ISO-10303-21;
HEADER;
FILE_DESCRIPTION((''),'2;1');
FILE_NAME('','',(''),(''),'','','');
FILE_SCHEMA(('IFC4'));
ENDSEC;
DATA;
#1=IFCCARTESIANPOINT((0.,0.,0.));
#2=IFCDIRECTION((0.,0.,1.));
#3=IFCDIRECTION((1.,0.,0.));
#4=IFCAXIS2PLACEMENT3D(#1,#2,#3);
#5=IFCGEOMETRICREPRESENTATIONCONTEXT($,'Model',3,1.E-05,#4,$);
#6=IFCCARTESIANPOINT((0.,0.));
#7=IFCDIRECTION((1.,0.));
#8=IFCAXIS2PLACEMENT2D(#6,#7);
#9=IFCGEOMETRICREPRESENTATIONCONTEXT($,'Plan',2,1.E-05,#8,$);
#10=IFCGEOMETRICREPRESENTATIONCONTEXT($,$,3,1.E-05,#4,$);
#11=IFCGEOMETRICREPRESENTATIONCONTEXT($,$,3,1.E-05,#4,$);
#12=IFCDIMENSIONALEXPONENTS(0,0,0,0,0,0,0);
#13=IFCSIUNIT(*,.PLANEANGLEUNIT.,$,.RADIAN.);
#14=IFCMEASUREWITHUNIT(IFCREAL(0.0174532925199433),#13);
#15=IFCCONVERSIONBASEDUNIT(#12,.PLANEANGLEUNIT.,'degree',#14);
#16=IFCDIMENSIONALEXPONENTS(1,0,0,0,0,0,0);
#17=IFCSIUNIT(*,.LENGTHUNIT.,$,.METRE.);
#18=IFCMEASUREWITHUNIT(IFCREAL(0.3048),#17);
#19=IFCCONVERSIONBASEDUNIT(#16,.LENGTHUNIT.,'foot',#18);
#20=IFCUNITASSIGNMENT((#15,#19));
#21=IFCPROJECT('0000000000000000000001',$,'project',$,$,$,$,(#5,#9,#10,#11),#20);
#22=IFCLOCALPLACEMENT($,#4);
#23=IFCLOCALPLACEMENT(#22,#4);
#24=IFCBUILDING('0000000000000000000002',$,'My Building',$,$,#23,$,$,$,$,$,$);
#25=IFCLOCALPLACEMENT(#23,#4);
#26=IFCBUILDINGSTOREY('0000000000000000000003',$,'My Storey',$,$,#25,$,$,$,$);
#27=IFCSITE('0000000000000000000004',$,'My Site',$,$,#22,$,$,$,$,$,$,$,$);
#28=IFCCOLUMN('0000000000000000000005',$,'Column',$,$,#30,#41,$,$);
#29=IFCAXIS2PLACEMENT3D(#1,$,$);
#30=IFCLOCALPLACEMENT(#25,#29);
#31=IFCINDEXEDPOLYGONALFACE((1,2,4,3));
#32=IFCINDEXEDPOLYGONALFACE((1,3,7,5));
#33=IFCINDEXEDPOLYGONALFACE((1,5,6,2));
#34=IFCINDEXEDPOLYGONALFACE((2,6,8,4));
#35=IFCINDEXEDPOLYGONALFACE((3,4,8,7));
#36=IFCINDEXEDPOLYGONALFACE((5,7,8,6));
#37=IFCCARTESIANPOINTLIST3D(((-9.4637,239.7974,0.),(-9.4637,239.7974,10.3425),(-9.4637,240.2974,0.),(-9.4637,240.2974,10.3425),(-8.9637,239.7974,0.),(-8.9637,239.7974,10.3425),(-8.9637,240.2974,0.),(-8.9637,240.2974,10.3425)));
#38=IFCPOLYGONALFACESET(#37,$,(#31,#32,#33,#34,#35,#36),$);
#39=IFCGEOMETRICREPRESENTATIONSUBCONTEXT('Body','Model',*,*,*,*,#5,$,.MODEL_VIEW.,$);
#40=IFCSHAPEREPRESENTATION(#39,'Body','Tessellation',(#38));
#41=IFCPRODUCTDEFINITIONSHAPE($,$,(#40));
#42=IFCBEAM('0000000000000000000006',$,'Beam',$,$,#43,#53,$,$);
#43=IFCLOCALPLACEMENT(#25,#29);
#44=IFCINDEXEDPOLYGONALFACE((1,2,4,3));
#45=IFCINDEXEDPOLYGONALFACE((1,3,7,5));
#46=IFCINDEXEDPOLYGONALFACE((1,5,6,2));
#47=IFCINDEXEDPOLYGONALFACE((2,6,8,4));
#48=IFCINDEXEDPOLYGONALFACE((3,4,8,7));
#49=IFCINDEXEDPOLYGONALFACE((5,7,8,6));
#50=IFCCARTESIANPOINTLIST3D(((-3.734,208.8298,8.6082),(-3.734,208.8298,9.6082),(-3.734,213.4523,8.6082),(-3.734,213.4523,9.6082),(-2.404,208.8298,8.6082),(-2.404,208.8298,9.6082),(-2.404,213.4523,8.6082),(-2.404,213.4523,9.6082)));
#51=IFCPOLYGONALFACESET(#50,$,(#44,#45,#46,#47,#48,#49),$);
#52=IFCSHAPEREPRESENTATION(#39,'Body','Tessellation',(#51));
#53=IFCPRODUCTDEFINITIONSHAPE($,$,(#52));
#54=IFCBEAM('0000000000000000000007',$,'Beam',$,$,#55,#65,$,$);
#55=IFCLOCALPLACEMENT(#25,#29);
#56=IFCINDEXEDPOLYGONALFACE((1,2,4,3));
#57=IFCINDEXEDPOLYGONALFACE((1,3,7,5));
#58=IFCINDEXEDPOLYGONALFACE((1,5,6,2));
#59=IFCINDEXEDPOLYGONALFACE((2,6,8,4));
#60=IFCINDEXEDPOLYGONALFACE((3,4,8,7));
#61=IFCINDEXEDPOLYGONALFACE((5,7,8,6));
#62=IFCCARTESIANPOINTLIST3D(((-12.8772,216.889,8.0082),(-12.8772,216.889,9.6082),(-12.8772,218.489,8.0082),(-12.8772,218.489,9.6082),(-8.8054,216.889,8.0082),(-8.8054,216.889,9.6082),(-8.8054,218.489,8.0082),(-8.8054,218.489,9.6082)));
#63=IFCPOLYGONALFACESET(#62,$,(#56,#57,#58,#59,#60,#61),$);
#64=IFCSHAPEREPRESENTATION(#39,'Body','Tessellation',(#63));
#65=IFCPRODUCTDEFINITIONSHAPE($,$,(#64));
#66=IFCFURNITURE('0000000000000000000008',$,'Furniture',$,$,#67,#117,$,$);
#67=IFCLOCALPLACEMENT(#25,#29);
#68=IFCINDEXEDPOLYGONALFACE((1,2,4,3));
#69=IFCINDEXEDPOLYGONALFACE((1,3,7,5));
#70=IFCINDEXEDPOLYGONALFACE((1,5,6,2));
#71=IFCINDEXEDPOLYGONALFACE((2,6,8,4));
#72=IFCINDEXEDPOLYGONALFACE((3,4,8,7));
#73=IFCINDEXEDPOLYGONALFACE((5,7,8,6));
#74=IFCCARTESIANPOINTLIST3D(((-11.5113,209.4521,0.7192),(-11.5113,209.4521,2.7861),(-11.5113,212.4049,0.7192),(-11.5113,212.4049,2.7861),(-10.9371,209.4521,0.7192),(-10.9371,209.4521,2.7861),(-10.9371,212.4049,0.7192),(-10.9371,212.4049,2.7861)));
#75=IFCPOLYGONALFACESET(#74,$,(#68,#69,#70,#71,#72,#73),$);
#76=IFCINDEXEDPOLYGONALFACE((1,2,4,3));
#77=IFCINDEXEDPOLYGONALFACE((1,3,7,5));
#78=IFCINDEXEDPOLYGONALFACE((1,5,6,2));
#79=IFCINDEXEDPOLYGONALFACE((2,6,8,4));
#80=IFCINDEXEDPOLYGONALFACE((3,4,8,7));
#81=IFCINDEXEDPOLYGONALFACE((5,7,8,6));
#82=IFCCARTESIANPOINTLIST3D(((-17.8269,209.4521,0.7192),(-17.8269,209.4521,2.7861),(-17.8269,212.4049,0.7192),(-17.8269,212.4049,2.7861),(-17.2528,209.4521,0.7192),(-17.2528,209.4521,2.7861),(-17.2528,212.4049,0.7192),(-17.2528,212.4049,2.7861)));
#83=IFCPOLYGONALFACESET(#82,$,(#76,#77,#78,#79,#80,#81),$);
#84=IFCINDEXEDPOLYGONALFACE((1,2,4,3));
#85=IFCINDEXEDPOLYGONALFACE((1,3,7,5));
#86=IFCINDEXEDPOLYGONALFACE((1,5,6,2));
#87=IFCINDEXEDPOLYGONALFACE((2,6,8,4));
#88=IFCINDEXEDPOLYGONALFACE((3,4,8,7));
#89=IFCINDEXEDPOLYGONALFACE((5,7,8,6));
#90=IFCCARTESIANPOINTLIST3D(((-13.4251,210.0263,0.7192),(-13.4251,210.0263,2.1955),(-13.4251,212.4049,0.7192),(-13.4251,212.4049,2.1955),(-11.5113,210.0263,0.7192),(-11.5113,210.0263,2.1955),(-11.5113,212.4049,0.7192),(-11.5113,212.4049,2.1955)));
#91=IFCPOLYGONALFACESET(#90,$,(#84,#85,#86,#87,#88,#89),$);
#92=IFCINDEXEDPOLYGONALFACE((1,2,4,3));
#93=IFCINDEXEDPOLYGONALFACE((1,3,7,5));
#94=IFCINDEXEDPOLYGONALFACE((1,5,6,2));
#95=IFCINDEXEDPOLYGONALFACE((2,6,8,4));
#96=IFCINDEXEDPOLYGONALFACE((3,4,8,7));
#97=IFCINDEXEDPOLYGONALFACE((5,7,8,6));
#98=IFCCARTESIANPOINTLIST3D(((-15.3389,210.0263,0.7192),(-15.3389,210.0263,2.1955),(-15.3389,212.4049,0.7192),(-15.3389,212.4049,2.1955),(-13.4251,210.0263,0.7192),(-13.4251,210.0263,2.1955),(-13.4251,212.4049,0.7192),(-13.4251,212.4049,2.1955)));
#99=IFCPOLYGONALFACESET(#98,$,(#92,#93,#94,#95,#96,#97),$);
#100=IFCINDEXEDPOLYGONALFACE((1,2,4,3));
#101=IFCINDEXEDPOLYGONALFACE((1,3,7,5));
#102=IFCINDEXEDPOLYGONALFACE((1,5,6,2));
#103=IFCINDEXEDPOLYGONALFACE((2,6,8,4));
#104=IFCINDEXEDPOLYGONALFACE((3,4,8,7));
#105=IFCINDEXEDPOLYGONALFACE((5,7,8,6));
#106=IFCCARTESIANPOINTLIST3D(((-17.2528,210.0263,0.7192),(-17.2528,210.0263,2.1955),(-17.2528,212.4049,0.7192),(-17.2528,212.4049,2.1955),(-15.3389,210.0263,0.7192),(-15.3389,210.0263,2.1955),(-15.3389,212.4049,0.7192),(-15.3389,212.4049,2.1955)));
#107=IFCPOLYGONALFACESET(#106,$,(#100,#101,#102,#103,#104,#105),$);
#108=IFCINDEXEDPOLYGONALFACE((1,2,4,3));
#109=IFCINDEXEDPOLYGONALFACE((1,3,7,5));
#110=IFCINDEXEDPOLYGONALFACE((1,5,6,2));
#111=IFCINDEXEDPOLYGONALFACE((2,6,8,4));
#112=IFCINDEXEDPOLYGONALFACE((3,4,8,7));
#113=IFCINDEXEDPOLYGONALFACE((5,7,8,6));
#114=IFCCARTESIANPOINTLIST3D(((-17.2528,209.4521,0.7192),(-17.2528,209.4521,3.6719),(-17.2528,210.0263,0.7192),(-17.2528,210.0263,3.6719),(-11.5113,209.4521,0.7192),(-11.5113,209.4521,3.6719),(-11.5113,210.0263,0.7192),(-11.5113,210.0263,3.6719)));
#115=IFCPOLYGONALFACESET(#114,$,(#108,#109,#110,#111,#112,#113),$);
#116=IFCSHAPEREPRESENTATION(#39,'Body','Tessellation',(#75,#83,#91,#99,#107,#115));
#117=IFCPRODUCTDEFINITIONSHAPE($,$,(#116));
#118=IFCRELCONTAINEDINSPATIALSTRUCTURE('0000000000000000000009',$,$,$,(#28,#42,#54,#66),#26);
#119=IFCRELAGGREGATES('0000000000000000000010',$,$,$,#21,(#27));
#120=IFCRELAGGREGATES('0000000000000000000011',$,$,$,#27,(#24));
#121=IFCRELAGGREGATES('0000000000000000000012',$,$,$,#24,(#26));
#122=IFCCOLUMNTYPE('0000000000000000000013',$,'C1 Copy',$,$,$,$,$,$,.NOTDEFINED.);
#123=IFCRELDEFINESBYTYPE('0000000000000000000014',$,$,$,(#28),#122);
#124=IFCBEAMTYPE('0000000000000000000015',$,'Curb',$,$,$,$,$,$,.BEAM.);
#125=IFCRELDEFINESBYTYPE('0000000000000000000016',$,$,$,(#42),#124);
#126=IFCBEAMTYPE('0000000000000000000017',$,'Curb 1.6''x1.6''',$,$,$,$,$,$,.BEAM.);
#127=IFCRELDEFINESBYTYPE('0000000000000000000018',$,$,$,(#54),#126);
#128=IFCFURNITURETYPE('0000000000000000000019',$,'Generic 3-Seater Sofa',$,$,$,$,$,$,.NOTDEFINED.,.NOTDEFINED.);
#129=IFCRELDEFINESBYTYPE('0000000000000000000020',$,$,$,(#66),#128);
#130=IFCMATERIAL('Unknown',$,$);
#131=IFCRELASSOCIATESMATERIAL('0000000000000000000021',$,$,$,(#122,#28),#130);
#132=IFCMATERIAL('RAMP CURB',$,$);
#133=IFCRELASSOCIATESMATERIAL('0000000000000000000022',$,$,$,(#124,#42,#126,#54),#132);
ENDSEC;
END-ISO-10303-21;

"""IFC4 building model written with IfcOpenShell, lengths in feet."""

from ifc_helpers import new_model, entity, si_unit, converted_unit, frame, origin_with_axes, origin_2d_with_axis, place, context, subcontext, project, spatial, line, indexed_curve, rectangle, outline, extrude, shape, source, transform, mapped, material, material_profile, profile_set, profile_usage, type_object, type_shapes, element, save


model = new_model("IFC4")

# Units and contexts
model_context = context("Model", 3, precision=1e-05, world=origin_with_axes())
plan_context = context("Plan", 2, precision=1e-05, world=origin_2d_with_axis())
context_of_model_1 = context(None, 3, precision=1e-05, world=origin_with_axes())
context_of_model_2 = context(None, 3, precision=1e-05, world=origin_with_axes())
body_context_1 = subcontext(model_context, "Body", "Model", "MODEL_VIEW")
body_context_2 = subcontext(plan_context, "Body", "Plan", "PLAN_VIEW")
ifc_project = project(units=[converted_unit("PLANEANGLEUNIT", "degree", entity("IfcReal", 0.0174532925199433), si_unit("PLANEANGLEUNIT", "RADIAN"), dimensions=[0, 0, 0, 0, 0, 0, 0]), converted_unit("LENGTHUNIT", "foot", entity("IfcReal", 0.3048), si_unit("LENGTHUNIT", "METRE"), dimensions=[1, 0, 0, 0, 0, 0, 0])], contexts=[model_context, plan_context, context_of_model_1, context_of_model_2])

# Site, building, storey
site_placement = place(None, origin_with_axes())
site = spatial("IfcSite", under=ifc_project, at=site_placement, Name="My Site")
building_placement = place(site_placement, origin_with_axes())
building = spatial("IfcBuilding", under=site, at=building_placement, Name="My Building")
storey_placement = place(building_placement, origin_with_axes())
storey = spatial("IfcBuildingStorey", under=building, at=storey_placement, Name="My Storey")

# Column
ifc_material_1 = material(Name="Unknown")
ifc_material_profile_1 = material_profile(ifc_material_1, rectangle(XDim=0.5, YDim=0.5))
ifc_profile_set_1 = profile_set([ifc_material_profile_1])
ifc_profile_usage_1 = profile_usage(ifc_profile_set_1, cardinal=5)
column_type = type_object("IfcColumnType", Name="C1 Copy", PredefinedType="NOTDEFINED", material=ifc_profile_set_1)
column_placement = place(storey_placement, frame((-9.2137, 240.0474, 0.0), z_axis=(0.0, 0.0, 1.0), x_axis=(1.0, 0.0, 0.0)))
element("IfcColumn", 1, at=column_placement, inside=storey, type_object=column_type, material=ifc_profile_usage_1, Name="Column", context=body_context_1, shape_type="SweptSolid", body=[
    extrude(rectangle(XDim=0.5, YDim=0.5), origin_with_axes(), (0.0, 0.0, 1.0), 10.3425),
])

# Beams
ifc_material_2 = material(Name="RAMP CURB")
ifc_material_profile_2 = material_profile(ifc_material_2, rectangle(XDim=1.33, YDim=1.0))
ifc_profile_set_2 = profile_set([ifc_material_profile_2])
ifc_profile_usage_2 = profile_usage(ifc_profile_set_2, cardinal=5)
beam_type_1 = type_object("IfcBeamType", Name="Curb", PredefinedType="BEAM", material=ifc_profile_set_2)
beam_1_placement = place(storey_placement, frame((-3.069, 208.8298, 9.1082), z_axis=(0.0, 1.0, 0.0), x_axis=(-1.0, 0.0, 0.0)))
element("IfcBeam", 2, at=beam_1_placement, inside=storey, type_object=beam_type_1, material=ifc_profile_usage_2, Name="Beam", context=body_context_1, shape_type="SweptSolid", body=[
    extrude(rectangle(XDim=1.33, YDim=1.0), origin_with_axes(), (0.0, 0.0, 1.0), 4.6225),
])
ifc_material_profile_3 = material_profile(ifc_material_2, rectangle(XDim=1.6, YDim=1.6))
ifc_profile_set_3 = profile_set([ifc_material_profile_3])
ifc_profile_usage_3 = profile_usage(ifc_profile_set_3, cardinal=5)
beam_type_2 = type_object("IfcBeamType", Name="Curb 1.6'x1.6'", PredefinedType="BEAM", material=ifc_profile_set_3)
beam_2_placement = place(storey_placement, frame((-8.8054, 217.689, 8.8082), z_axis=(-1.0, 0.0, 0.0), x_axis=(0.0, -1.0, 0.0)))
element("IfcBeam", 3, at=beam_2_placement, inside=storey, type_object=beam_type_2, material=ifc_profile_usage_3, Name="Beam", context=body_context_1, shape_type="SweptSolid", body=[
    extrude(rectangle(XDim=1.6, YDim=1.6), origin_with_axes(), (0.0, 0.0, 1.0), 4.0718),
])

# Furniture
furniture_type_1 = type_object("IfcFurnitureType", Name="Generic 3-Seater Sofa", AssemblyPlace="NOTDEFINED", PredefinedType="NOTDEFINED")
shared_shape_1 = source(origin_with_axes(), body_context_1, "Body", "SweptSolid", [
    extrude(outline(indexed_curve([(0.0, 0.0), (0.5741, 0.0), (0.5741, 2.9528), (0.0, 2.9528)], segments=[line(1, 2), line(2, 3), line(3, 4), line(4, 1)])), frame((-3.4449, -2.9528, 0.0), z_axis=(0.0, 0.0, 1.0), x_axis=(1.0, 0.0, 0.0)), (0.0, 0.0, 1.0), 2.0669),
    extrude(outline(indexed_curve([(0.0, 0.0), (0.5741, 0.0), (0.5741, 2.9528), (0.0, 2.9528)], segments=[line(1, 2), line(2, 3), line(3, 4), line(4, 1)])), frame((2.8707, -2.9528, 0.0), z_axis=(0.0, 0.0, 1.0), x_axis=(1.0, 0.0, 0.0)), (0.0, 0.0, 1.0), 2.0669),
    extrude(outline(indexed_curve([(0.5741, 0.0), (2.488, 0.0), (2.488, 2.3786), (0.5741, 2.3786)], segments=[line(1, 2), line(2, 3), line(3, 4), line(4, 1)])), frame((-3.4449, -2.9528, 0.0), z_axis=(0.0, 0.0, 1.0), x_axis=(1.0, 0.0, 0.0)), (0.0, 0.0, 1.0), 1.4764),
    extrude(outline(indexed_curve([(2.488, 0.0), (4.4018, 0.0), (4.4018, 2.3786), (2.488, 2.3786)], segments=[line(1, 2), line(2, 3), line(3, 4), line(4, 1)])), frame((-3.4449, -2.9528, 0.0), z_axis=(0.0, 0.0, 1.0), x_axis=(1.0, 0.0, 0.0)), (0.0, 0.0, 1.0), 1.4764),
    extrude(outline(indexed_curve([(4.4018, 0.0), (6.3156, 0.0), (6.3156, 2.3786), (4.4018, 2.3786)], segments=[line(1, 2), line(2, 3), line(3, 4), line(4, 1)])), frame((-3.4449, -2.9528, 0.0), z_axis=(0.0, 0.0, 1.0), x_axis=(1.0, 0.0, 0.0)), (0.0, 0.0, 1.0), 1.4764),
    extrude(outline(indexed_curve([(0.5741, 2.3786), (6.3156, 2.3786), (6.3156, 2.9528), (0.5741, 2.9528)], segments=[line(1, 2), line(2, 3), line(3, 4), line(4, 1)])), frame((-3.4449, -2.9528, 0.0), z_axis=(0.0, 0.0, 1.0), x_axis=(1.0, 0.0, 0.0)), (0.0, 0.0, 1.0), 2.9528),
])
shared_shape_2 = source(origin_with_axes(), body_context_2, "Body", "Annotation2D", [
    entity("IfcAnnotationFillArea", entity("IfcIndexedPolyCurve", entity("IfcCartesianPointList2D", [[-3.4449, -2.9528], [-2.8707, -2.9528], [-2.8707, 0.0], [-3.4449, 0.0], [2.8707, -2.9528], [3.4449, -2.9528], [3.4449, 0.0], [2.8707, 0.0], [-2.8707, -2.9528], [-0.9569, -2.9528], [-0.9569, -2.9528], [-0.9569, -0.5741], [-2.8707, -0.5741], [-0.9569, -2.9528], [0.9569, -2.9528], [0.9569, -2.9528], [0.9569, -0.5741], [-0.9569, -0.5741], [-0.9569, -0.5741], [0.9569, -2.9528], [2.8707, -2.9528], [2.8707, -0.5741], [0.9569, -0.5741], [-2.8707, -0.5741], [2.8707, -0.5741], [2.8707, 0.0], [-2.8707, 0.0], [0.9569, -0.5741]]), [entity("IfcLineIndex", [5, 8]), entity("IfcLineIndex", [8, 7]), entity("IfcLineIndex", [7, 6]), entity("IfcLineIndex", [6, 5])])),
    entity("IfcAnnotationFillArea", entity("IfcIndexedPolyCurve", entity("IfcCartesianPointList2D", [[-3.4449, -2.9528], [-2.8707, -2.9528], [-2.8707, 0.0], [-3.4449, 0.0], [2.8707, -2.9528], [3.4449, -2.9528], [3.4449, 0.0], [2.8707, 0.0], [-2.8707, -2.9528], [-0.9569, -2.9528], [-0.9569, -2.9528], [-0.9569, -0.5741], [-2.8707, -0.5741], [-0.9569, -2.9528], [0.9569, -2.9528], [0.9569, -2.9528], [0.9569, -0.5741], [-0.9569, -0.5741], [-0.9569, -0.5741], [0.9569, -2.9528], [2.8707, -2.9528], [2.8707, -0.5741], [0.9569, -0.5741], [-2.8707, -0.5741], [2.8707, -0.5741], [2.8707, 0.0], [-2.8707, 0.0], [0.9569, -0.5741]]), [entity("IfcLineIndex", [20, 23]), entity("IfcLineIndex", [23, 22]), entity("IfcLineIndex", [22, 21]), entity("IfcLineIndex", [21, 20])])),
    entity("IfcAnnotationFillArea", entity("IfcIndexedPolyCurve", entity("IfcCartesianPointList2D", [[-3.4449, -2.9528], [-2.8707, -2.9528], [-2.8707, 0.0], [-3.4449, 0.0], [2.8707, -2.9528], [3.4449, -2.9528], [3.4449, 0.0], [2.8707, 0.0], [-2.8707, -2.9528], [-0.9569, -2.9528], [-0.9569, -2.9528], [-0.9569, -0.5741], [-2.8707, -0.5741], [-0.9569, -2.9528], [0.9569, -2.9528], [0.9569, -2.9528], [0.9569, -0.5741], [-0.9569, -0.5741], [-0.9569, -0.5741], [0.9569, -2.9528], [2.8707, -2.9528], [2.8707, -0.5741], [0.9569, -0.5741], [-2.8707, -0.5741], [2.8707, -0.5741], [2.8707, 0.0], [-2.8707, 0.0], [0.9569, -0.5741]]), [entity("IfcLineIndex", [1, 4]), entity("IfcLineIndex", [4, 3]), entity("IfcLineIndex", [3, 2]), entity("IfcLineIndex", [2, 1])])),
    entity("IfcAnnotationFillArea", entity("IfcIndexedPolyCurve", entity("IfcCartesianPointList2D", [[-3.4449, -2.9528], [-2.8707, -2.9528], [-2.8707, 0.0], [-3.4449, 0.0], [2.8707, -2.9528], [3.4449, -2.9528], [3.4449, 0.0], [2.8707, 0.0], [-2.8707, -2.9528], [-0.9569, -2.9528], [-0.9569, -2.9528], [-0.9569, -0.5741], [-2.8707, -0.5741], [-0.9569, -2.9528], [0.9569, -2.9528], [0.9569, -2.9528], [0.9569, -0.5741], [-0.9569, -0.5741], [-0.9569, -0.5741], [0.9569, -2.9528], [2.8707, -2.9528], [2.8707, -0.5741], [0.9569, -0.5741], [-2.8707, -0.5741], [2.8707, -0.5741], [2.8707, 0.0], [-2.8707, 0.0], [0.9569, -0.5741]]), [entity("IfcLineIndex", [9, 13]), entity("IfcLineIndex", [13, 12]), entity("IfcLineIndex", [12, 11]), entity("IfcLineIndex", [11, 10]), entity("IfcLineIndex", [10, 9])])),
    entity("IfcAnnotationFillArea", entity("IfcIndexedPolyCurve", entity("IfcCartesianPointList2D", [[-3.4449, -2.9528], [-2.8707, -2.9528], [-2.8707, 0.0], [-3.4449, 0.0], [2.8707, -2.9528], [3.4449, -2.9528], [3.4449, 0.0], [2.8707, 0.0], [-2.8707, -2.9528], [-0.9569, -2.9528], [-0.9569, -2.9528], [-0.9569, -0.5741], [-2.8707, -0.5741], [-0.9569, -2.9528], [0.9569, -2.9528], [0.9569, -2.9528], [0.9569, -0.5741], [-0.9569, -0.5741], [-0.9569, -0.5741], [0.9569, -2.9528], [2.8707, -2.9528], [2.8707, -0.5741], [0.9569, -0.5741], [-2.8707, -0.5741], [2.8707, -0.5741], [2.8707, 0.0], [-2.8707, 0.0], [0.9569, -0.5741]]), [entity("IfcLineIndex", [14, 19]), entity("IfcLineIndex", [19, 28]), entity("IfcLineIndex", [28, 15]), entity("IfcLineIndex", [15, 14])])),
    entity("IfcAnnotationFillArea", entity("IfcIndexedPolyCurve", entity("IfcCartesianPointList2D", [[-3.4449, -2.9528], [-2.8707, -2.9528], [-2.8707, 0.0], [-3.4449, 0.0], [2.8707, -2.9528], [3.4449, -2.9528], [3.4449, 0.0], [2.8707, 0.0], [-2.8707, -2.9528], [-0.9569, -2.9528], [-0.9569, -2.9528], [-0.9569, -0.5741], [-2.8707, -0.5741], [-0.9569, -2.9528], [0.9569, -2.9528], [0.9569, -2.9528], [0.9569, -0.5741], [-0.9569, -0.5741], [-0.9569, -0.5741], [0.9569, -2.9528], [2.8707, -2.9528], [2.8707, -0.5741], [0.9569, -0.5741], [-2.8707, -0.5741], [2.8707, -0.5741], [2.8707, 0.0], [-2.8707, 0.0], [0.9569, -0.5741]]), [entity("IfcLineIndex", [24, 27]), entity("IfcLineIndex", [27, 26]), entity("IfcLineIndex", [26, 25]), entity("IfcLineIndex", [25, 24])])),
])
type_shapes(furniture_type_1, [shared_shape_1, shared_shape_2])
for number, where, z_axis, x_axis, name in (
    (4, (-14.382, 209.4521, 0.7192), (0.0, 0.0, 1.0), (-1.0, 0.0, 0.0), "Furniture"),
):
    element("IfcFurniture", number, at=place(storey_placement, frame(where, z_axis=z_axis, x_axis=x_axis)), inside=storey, type_object=furniture_type_1, Name=name, shapes=[
        shape(body_context_1, "Body", "MappedRepresentation", [mapped(shared_shape_1, transform((0.0, 0.0, 0.0), x_axis=(1.0, 0.0, 0.0), y_axis=(0.0, 1.0, 0.0), z_axis=(0.0, 0.0, 1.0), scale=1.0))]),
        shape(body_context_2, "Body", "MappedRepresentation", [mapped(shared_shape_2, transform((0.0, 0.0, 0.0), x_axis=(1.0, 0.0, 0.0), y_axis=(0.0, 1.0, 0.0), z_axis=(0.0, 0.0, 1.0), scale=1.0))]),
    ])

save(model, "model.ifc")
